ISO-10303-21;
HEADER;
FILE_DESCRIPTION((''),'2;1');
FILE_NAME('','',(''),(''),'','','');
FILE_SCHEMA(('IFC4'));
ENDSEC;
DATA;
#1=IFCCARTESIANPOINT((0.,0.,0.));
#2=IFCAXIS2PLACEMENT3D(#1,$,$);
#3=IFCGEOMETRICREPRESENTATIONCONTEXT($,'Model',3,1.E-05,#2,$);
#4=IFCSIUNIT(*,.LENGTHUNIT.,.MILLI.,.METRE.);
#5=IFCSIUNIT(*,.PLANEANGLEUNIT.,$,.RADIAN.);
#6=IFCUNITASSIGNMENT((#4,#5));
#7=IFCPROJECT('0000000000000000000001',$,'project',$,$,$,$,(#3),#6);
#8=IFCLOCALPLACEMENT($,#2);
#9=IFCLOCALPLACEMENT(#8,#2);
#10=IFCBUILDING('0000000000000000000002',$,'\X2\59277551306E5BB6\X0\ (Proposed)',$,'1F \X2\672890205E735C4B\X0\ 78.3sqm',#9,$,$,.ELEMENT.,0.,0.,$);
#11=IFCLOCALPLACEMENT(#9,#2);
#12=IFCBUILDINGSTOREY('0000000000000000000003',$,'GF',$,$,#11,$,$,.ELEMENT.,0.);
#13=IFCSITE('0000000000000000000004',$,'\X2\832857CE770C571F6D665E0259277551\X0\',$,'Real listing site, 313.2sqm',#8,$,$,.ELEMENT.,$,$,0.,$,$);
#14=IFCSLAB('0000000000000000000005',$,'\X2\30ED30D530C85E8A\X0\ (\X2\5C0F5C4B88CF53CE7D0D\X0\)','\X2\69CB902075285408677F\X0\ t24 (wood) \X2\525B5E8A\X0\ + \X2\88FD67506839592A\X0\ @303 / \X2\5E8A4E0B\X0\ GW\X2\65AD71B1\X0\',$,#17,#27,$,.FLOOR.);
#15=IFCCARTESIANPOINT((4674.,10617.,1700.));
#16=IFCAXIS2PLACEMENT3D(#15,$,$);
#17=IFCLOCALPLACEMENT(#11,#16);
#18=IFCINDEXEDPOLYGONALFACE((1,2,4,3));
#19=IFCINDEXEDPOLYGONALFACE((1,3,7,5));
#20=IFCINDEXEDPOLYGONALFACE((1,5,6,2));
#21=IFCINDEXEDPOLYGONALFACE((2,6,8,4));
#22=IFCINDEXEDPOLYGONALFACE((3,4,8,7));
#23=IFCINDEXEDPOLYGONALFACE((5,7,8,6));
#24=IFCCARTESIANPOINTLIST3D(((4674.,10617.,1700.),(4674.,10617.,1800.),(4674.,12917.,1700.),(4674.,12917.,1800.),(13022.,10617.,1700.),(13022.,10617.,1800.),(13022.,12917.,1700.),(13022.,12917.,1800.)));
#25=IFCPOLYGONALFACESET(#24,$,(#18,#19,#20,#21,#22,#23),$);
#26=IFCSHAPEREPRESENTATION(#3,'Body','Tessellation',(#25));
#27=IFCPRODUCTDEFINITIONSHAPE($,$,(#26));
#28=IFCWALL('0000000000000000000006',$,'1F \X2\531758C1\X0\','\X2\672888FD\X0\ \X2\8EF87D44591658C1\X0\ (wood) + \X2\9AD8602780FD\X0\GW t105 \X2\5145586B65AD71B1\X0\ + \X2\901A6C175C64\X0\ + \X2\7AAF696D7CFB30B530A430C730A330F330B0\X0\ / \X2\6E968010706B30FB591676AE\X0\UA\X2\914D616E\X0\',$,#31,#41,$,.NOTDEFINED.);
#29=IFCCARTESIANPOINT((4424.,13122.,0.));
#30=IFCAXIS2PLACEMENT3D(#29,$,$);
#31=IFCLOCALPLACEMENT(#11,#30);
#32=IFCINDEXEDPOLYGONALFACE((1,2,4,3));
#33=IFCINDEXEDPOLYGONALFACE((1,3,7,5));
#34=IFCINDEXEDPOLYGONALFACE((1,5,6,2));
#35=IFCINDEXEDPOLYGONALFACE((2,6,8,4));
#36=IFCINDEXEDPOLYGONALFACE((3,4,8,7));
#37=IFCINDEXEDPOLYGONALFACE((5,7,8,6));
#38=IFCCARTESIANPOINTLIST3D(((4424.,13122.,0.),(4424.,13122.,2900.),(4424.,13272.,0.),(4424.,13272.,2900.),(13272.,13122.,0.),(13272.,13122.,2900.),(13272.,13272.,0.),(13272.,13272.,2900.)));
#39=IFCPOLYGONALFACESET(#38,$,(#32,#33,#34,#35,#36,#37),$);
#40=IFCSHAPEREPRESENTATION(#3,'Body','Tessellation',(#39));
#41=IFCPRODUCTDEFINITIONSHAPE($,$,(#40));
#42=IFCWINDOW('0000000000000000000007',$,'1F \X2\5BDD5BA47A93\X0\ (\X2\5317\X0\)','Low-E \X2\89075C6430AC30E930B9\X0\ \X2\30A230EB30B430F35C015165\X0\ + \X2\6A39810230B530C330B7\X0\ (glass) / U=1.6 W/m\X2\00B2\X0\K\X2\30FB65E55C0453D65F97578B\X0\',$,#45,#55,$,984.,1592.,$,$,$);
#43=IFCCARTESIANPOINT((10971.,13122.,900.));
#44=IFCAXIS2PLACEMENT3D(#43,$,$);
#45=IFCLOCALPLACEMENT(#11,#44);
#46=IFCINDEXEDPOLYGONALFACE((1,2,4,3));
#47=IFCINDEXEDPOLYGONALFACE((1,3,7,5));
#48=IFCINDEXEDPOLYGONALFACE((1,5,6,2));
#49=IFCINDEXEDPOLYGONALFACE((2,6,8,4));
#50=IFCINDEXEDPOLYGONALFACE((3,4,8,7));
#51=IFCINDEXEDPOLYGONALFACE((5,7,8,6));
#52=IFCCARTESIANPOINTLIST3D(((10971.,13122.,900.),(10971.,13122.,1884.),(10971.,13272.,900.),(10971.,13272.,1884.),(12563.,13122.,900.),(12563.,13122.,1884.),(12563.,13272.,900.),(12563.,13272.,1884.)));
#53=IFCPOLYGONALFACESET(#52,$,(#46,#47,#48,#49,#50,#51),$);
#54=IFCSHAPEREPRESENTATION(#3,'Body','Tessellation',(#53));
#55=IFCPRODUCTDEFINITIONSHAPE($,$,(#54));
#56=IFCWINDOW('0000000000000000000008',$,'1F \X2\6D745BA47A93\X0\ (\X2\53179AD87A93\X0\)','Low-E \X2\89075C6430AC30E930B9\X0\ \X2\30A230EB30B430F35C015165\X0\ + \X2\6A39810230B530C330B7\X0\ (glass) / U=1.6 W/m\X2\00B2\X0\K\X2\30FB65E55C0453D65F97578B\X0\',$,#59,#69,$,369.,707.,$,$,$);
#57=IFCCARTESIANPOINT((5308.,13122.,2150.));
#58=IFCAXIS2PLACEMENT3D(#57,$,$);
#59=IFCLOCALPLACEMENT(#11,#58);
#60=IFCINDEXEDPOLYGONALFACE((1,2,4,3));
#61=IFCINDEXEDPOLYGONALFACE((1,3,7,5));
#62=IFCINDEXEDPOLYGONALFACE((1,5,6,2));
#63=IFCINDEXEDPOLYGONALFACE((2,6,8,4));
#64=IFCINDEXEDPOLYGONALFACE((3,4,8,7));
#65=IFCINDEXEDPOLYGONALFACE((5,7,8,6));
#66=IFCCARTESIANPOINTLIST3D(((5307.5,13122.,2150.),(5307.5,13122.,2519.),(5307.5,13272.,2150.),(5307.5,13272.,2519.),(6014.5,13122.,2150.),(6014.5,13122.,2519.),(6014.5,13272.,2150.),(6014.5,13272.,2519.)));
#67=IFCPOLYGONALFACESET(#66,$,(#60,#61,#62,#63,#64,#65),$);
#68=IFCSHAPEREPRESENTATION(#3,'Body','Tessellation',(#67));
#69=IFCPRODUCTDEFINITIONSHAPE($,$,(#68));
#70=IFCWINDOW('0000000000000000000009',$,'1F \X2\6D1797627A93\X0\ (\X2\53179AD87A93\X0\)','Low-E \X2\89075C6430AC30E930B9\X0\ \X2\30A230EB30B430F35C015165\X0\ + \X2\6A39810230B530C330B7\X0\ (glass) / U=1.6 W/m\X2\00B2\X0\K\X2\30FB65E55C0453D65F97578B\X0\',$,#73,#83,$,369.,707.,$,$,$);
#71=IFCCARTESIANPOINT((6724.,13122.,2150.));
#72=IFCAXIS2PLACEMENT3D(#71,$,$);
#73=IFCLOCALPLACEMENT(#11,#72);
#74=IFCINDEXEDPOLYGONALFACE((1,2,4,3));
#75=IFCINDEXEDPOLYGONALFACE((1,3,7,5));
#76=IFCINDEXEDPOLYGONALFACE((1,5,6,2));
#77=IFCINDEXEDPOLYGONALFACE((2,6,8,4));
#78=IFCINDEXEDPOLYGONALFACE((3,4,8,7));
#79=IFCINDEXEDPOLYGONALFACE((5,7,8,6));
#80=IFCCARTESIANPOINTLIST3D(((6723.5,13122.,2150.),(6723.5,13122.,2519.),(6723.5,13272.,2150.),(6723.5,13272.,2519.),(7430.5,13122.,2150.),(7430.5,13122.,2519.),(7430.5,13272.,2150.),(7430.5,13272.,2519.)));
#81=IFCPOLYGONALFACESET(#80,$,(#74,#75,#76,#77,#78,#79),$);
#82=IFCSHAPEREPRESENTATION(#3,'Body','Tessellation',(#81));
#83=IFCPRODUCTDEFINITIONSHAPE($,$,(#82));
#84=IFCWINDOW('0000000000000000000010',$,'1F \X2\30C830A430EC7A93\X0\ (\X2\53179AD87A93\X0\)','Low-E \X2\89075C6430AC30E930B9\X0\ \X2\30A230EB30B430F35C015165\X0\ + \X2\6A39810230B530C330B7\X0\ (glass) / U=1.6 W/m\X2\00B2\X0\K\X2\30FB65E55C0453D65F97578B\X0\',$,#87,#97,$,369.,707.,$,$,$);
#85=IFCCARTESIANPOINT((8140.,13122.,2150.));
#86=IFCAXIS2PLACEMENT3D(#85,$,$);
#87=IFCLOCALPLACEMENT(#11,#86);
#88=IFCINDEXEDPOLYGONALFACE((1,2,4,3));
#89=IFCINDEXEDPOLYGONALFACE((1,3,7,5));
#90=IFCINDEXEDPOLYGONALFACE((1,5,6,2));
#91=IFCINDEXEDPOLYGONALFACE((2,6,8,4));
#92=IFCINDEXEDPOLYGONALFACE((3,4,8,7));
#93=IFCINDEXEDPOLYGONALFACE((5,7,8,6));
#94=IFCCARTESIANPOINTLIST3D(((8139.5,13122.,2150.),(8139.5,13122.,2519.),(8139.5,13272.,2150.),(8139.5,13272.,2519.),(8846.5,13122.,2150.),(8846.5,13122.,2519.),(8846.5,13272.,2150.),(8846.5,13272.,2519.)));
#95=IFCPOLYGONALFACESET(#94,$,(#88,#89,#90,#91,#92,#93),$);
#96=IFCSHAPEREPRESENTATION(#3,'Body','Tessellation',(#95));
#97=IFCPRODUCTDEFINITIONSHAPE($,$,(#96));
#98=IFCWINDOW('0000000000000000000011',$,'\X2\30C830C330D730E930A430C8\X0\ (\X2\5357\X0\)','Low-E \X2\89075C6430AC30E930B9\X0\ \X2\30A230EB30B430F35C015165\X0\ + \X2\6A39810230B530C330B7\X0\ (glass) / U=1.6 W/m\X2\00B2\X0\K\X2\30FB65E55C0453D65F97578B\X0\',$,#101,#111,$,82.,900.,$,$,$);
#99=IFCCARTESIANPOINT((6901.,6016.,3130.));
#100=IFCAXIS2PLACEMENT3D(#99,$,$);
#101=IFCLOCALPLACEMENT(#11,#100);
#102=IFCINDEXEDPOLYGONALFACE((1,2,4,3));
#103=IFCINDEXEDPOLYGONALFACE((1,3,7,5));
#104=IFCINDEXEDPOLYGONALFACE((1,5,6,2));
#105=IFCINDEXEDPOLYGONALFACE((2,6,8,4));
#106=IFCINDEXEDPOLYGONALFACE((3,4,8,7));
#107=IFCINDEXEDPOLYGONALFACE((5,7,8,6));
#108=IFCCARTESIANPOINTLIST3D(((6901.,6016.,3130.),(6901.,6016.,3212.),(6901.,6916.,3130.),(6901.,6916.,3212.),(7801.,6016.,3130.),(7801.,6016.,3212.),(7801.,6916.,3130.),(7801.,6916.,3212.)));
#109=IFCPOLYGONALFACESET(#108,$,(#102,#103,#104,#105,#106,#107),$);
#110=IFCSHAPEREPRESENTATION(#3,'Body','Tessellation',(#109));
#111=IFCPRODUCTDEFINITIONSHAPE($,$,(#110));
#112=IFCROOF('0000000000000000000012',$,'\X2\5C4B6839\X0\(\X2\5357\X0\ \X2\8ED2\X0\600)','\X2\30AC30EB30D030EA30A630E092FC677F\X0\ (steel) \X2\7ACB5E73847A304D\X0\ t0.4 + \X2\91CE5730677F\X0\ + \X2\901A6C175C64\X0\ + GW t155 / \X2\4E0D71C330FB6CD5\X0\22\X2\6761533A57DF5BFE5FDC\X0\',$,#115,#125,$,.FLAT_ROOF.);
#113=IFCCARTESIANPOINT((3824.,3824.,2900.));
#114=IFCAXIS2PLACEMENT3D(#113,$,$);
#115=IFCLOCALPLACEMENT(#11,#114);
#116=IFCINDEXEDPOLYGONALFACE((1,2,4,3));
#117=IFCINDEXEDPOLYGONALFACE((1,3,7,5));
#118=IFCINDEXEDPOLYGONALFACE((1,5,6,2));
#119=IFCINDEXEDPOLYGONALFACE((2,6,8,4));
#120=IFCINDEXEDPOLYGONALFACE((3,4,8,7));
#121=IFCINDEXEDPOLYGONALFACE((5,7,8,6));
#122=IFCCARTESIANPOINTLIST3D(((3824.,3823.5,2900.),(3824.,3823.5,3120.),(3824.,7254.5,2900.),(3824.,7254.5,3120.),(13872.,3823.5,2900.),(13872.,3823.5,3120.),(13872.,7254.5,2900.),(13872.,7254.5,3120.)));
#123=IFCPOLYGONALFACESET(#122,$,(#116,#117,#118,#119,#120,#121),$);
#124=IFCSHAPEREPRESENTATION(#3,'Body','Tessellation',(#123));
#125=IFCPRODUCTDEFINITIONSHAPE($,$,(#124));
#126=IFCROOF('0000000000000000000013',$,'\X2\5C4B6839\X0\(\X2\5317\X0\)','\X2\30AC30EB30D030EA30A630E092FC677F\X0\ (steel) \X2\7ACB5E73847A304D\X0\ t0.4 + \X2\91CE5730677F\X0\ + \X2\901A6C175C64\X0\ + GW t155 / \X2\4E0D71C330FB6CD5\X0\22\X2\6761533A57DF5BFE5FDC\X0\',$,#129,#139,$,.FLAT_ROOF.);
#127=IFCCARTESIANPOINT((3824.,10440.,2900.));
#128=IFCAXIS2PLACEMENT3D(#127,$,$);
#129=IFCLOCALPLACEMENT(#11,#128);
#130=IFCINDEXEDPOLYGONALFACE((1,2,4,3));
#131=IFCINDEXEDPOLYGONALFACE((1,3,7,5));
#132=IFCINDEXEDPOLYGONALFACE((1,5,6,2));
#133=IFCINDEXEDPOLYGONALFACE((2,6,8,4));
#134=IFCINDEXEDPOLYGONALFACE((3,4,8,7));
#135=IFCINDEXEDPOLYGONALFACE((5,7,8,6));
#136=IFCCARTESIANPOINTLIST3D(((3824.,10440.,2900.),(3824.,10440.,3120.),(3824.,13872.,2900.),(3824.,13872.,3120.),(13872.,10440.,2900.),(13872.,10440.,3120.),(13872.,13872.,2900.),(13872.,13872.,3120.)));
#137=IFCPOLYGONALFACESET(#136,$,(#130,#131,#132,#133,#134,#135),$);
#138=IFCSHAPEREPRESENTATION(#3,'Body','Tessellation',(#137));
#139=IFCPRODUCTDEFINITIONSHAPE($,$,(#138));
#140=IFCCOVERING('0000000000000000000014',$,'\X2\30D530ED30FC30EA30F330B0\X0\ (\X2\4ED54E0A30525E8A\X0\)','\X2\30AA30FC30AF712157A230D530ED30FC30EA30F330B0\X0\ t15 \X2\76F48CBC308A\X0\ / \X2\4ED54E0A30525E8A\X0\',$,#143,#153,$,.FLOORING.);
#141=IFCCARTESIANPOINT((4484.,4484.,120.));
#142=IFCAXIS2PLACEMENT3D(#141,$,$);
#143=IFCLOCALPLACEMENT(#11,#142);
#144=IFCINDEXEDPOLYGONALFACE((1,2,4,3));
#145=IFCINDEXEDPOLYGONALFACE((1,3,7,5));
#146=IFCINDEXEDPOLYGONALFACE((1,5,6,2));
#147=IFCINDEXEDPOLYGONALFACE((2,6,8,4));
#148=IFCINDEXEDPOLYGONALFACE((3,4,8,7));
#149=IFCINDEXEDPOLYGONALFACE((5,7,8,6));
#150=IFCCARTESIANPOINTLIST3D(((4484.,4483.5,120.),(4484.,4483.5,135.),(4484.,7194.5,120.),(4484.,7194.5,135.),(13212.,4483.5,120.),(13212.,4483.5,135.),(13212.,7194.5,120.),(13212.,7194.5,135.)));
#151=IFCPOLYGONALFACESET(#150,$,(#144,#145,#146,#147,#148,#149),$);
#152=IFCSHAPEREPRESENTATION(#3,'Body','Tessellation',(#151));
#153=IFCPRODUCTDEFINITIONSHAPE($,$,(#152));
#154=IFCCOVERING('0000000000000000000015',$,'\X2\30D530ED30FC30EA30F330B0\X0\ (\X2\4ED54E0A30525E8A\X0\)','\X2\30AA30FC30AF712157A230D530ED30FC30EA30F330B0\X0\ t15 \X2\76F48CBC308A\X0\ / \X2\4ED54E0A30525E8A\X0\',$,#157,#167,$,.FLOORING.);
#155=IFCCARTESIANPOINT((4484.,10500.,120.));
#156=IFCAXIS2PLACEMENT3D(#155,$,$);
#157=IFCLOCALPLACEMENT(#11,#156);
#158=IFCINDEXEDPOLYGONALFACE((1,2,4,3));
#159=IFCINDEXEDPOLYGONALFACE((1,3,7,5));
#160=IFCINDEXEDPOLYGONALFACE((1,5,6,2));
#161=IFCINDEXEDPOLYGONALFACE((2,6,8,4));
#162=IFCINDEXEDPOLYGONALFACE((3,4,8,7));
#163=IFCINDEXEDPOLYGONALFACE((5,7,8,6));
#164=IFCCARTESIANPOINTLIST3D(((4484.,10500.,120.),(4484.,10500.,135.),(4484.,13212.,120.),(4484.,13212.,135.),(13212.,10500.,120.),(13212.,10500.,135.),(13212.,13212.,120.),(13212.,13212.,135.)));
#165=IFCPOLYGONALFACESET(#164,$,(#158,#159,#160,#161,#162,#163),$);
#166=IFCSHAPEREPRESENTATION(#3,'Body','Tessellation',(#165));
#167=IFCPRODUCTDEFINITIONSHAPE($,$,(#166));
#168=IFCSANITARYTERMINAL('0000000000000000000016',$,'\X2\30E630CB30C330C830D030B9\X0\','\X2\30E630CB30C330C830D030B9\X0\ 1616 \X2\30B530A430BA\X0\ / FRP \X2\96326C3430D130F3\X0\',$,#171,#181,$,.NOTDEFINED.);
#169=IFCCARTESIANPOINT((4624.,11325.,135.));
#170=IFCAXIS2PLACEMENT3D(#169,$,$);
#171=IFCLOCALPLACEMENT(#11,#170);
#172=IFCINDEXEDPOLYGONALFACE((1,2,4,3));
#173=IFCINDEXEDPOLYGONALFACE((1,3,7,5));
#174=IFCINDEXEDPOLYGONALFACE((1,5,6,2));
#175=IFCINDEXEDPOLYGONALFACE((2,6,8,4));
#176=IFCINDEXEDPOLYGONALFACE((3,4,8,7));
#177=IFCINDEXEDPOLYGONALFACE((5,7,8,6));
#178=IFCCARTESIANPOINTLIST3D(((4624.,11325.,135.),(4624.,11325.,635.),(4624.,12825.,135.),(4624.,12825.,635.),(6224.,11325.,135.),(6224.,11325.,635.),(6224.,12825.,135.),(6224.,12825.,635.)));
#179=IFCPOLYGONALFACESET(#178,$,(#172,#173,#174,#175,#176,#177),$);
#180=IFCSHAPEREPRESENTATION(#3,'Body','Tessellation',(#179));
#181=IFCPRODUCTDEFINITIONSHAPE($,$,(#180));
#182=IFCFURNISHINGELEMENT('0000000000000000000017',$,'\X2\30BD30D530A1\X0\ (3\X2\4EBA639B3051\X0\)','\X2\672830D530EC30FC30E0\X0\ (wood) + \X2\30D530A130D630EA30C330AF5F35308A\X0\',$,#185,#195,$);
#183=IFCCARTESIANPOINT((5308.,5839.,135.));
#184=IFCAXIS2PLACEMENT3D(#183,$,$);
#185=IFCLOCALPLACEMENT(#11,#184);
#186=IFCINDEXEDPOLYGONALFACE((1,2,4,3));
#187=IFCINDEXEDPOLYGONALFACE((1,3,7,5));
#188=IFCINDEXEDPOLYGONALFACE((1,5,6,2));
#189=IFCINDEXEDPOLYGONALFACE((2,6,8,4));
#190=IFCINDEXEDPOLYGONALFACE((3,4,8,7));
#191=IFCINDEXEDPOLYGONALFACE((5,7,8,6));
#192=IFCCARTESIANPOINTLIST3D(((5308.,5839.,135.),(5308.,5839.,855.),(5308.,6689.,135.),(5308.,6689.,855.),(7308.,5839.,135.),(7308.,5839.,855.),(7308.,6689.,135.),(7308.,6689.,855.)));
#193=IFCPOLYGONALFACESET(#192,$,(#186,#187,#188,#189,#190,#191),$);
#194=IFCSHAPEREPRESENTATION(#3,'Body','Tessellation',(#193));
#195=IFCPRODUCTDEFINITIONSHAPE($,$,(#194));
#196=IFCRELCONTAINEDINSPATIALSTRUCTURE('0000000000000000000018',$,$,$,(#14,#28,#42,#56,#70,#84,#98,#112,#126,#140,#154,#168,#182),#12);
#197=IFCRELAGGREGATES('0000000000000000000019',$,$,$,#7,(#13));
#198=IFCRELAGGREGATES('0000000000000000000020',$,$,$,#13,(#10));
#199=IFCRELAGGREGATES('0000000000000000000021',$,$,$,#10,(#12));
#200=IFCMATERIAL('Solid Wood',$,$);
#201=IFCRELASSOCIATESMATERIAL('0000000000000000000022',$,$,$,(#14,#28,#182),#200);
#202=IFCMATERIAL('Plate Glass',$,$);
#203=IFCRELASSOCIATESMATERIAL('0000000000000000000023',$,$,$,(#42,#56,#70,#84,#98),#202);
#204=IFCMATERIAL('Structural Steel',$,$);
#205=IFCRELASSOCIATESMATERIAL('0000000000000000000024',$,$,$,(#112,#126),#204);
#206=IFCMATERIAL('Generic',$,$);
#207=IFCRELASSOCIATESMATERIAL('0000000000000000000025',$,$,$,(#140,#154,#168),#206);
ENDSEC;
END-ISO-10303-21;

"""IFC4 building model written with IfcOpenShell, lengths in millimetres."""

from ifc_helpers import new_model, si_unit, frame, frame_2d, origin, place, context, project, spatial, rectangle, extrude, material, element, fill, save


model = new_model("IFC4")

# Units and contexts
model_context = context("Model", 3, precision=1e-05, world=origin())
ifc_project = project(units=[si_unit("LENGTHUNIT", "METRE", prefix="MILLI"), si_unit("PLANEANGLEUNIT", "RADIAN")], contexts=[model_context])

# Site, building, storey
site_placement = place(None, origin())
site = spatial("IfcSite", under=ifc_project, at=site_placement, Name="茨城県土浦市大畑", ObjectType="Real listing site, 313.2sqm", CompositionType="ELEMENT", RefElevation=0.0)
building_placement = place(site_placement, origin())
building = spatial("IfcBuilding", under=site, at=building_placement, Name="大畑の家 (Proposed)", ObjectType="1F 木造平屋 78.3sqm", CompositionType="ELEMENT", ElevationOfRefHeight=0.0, ElevationOfTerrain=0.0)
storey_placement = place(building_placement, origin())
storey = spatial("IfcBuildingStorey", under=building, at=storey_placement, Name="GF", CompositionType="ELEMENT", Elevation=0.0)

# Slab
ifc_material_1 = material(Name="Solid Wood")
slab_1_placement = place(storey_placement, frame((4674.0, 10617.0, 1700.0)))
element("IfcSlab", 1, at=slab_1_placement, inside=storey, material=ifc_material_1, Name="ロフト床 (小屋裏収納)", Description="構造用合板 t24 (wood) 剛床 + 製材根太 @303 / 床下 GW断熱", PredefinedType="FLOOR", context=model_context, shape_type="SweptSolid", body=[
    extrude(rectangle(XDim=8348.0, YDim=2300.0, at=frame_2d((4174.0, 1150.0))), frame((4674.0, 10617.0, 1700.0)), (0.0, 0.0, 1.0), 100.0),
])

# Shared definitions
ifc_material_2 = material(Name="Plate Glass")

# Wall, openings, windows
wall_1_placement = place(storey_placement, frame((4424.0, 13122.0, 0.0)))
wall_1 = element("IfcWall", 2, at=wall_1_placement, inside=storey, material=ifc_material_1, Name="1F 北壁", Description="木製 軸組外壁 (wood) + 高性能GW t105 充填断熱 + 通気層 + 窯業系サイディング / 準耐火・外皮UA配慮", PredefinedType="NOTDEFINED", context=model_context, shape_type="SweptSolid", body=[
    extrude(rectangle(XDim=8848.0, YDim=150.0, at=frame_2d((4424.0, 75.0))), frame((4424.0, 13122.0, 0.0)), (0.0, 0.0, 1.0), 2900.0),
])
opening_1_placement = place(storey_placement, frame((10971.0, 13122.0, 900.0)))
opening_1 = element("IfcOpeningElement", 3, at=opening_1_placement, cuts=wall_1, PredefinedType="NOTDEFINED", context=model_context, shape_type="SweptSolid", body=[
    extrude(rectangle(XDim=1592.0, YDim=150.0, at=frame_2d((796.0, 75.0))), frame((10971.0, 13122.0, 900.0)), (0.0, 0.0, 1.0), 984.0),
])
opening_2_placement = place(storey_placement, frame((5308.0, 13122.0, 2150.0)))
opening_2 = element("IfcOpeningElement", 4, at=opening_2_placement, cuts=wall_1, PredefinedType="NOTDEFINED", context=model_context, shape_type="SweptSolid", body=[
    extrude(rectangle(XDim=707.0, YDim=150.0, at=frame_2d((353.0, 75.0))), frame((5308.0, 13122.0, 2150.0)), (0.0, 0.0, 1.0), 369.0),
])
opening_3_placement = place(storey_placement, frame((6724.0, 13122.0, 2150.0)))
opening_3 = element("IfcOpeningElement", 5, at=opening_3_placement, cuts=wall_1, PredefinedType="NOTDEFINED", context=model_context, shape_type="SweptSolid", body=[
    extrude(rectangle(XDim=707.0, YDim=150.0, at=frame_2d((353.0, 75.0))), frame((6724.0, 13122.0, 2150.0)), (0.0, 0.0, 1.0), 369.0),
])
opening_4_placement = place(storey_placement, frame((8140.0, 13122.0, 2150.0)))
opening_4 = element("IfcOpeningElement", 6, at=opening_4_placement, cuts=wall_1, PredefinedType="NOTDEFINED", context=model_context, shape_type="SweptSolid", body=[
    extrude(rectangle(XDim=707.0, YDim=150.0, at=frame_2d((353.0, 75.0))), frame((8140.0, 13122.0, 2150.0)), (0.0, 0.0, 1.0), 369.0),
])
window_1_placement = place(storey_placement, frame((10971.0, 13122.0, 900.0)))
window_1 = element("IfcWindow", 7, at=window_1_placement, inside=storey, material=ifc_material_2, Name="1F 寝室窓 (北)", Description="Low-E 複層ガラス アルゴン封入 + 樹脂サッシ (glass) / U=1.6 W/m²K・日射取得型", OverallHeight=984.0, OverallWidth=1592.0, context=model_context, shape_type="SweptSolid", body=[
    extrude(rectangle(XDim=1592.0, YDim=150.0, at=frame_2d((796.0, 75.0))), frame((10971.0, 13122.0, 900.0)), (0.0, 0.0, 1.0), 984.0),
])
fill(opening_1, window_1)
window_2_placement = place(storey_placement, frame((5308.0, 13122.0, 2150.0)))
window_2 = element("IfcWindow", 8, at=window_2_placement, inside=storey, material=ifc_material_2, Name="1F 浴室窓 (北高窓)", Description="Low-E 複層ガラス アルゴン封入 + 樹脂サッシ (glass) / U=1.6 W/m²K・日射取得型", OverallHeight=369.0, OverallWidth=707.0, context=model_context, shape_type="SweptSolid", body=[
    extrude(rectangle(XDim=707.0, YDim=150.0, at=frame_2d((353.0, 75.0))), frame((5308.0, 13122.0, 2150.0)), (0.0, 0.0, 1.0), 369.0),
])
fill(opening_2, window_2)
window_3_placement = place(storey_placement, frame((6724.0, 13122.0, 2150.0)))
window_3 = element("IfcWindow", 9, at=window_3_placement, inside=storey, material=ifc_material_2, Name="1F 洗面窓 (北高窓)", Description="Low-E 複層ガラス アルゴン封入 + 樹脂サッシ (glass) / U=1.6 W/m²K・日射取得型", OverallHeight=369.0, OverallWidth=707.0, context=model_context, shape_type="SweptSolid", body=[
    extrude(rectangle(XDim=707.0, YDim=150.0, at=frame_2d((353.0, 75.0))), frame((6724.0, 13122.0, 2150.0)), (0.0, 0.0, 1.0), 369.0),
])
fill(opening_3, window_3)
window_4_placement = place(storey_placement, frame((8140.0, 13122.0, 2150.0)))
window_4 = element("IfcWindow", 10, at=window_4_placement, inside=storey, material=ifc_material_2, Name="1F トイレ窓 (北高窓)", Description="Low-E 複層ガラス アルゴン封入 + 樹脂サッシ (glass) / U=1.6 W/m²K・日射取得型", OverallHeight=369.0, OverallWidth=707.0, context=model_context, shape_type="SweptSolid", body=[
    extrude(rectangle(XDim=707.0, YDim=150.0, at=frame_2d((353.0, 75.0))), frame((8140.0, 13122.0, 2150.0)), (0.0, 0.0, 1.0), 369.0),
])
fill(opening_4, window_4)

# Window
window_5_placement = place(storey_placement, frame((6901.0, 6016.0, 3130.0)))
element("IfcWindow", 11, at=window_5_placement, inside=storey, material=ifc_material_2, Name="トップライト (南)", Description="Low-E 複層ガラス アルゴン封入 + 樹脂サッシ (glass) / U=1.6 W/m²K・日射取得型", OverallHeight=82.0, OverallWidth=900.0, context=model_context, shape_type="SweptSolid", body=[
    extrude(rectangle(XDim=900.0, YDim=900.0, at=frame_2d((450.0, 450.0))), frame((6901.0, 6016.0, 3130.0)), (0.0, 0.0, 1.0), 82.0),
])

# Roofs
ifc_material_3 = material(Name="Structural Steel")
roof_1_placement = place(storey_placement, frame((3824.0, 3824.0, 2900.0)))
element("IfcRoof", 12, at=roof_1_placement, inside=storey, material=ifc_material_3, Name="屋根(南 軒600)", Description="ガルバリウム鋼板 (steel) 立平葺き t0.4 + 野地板 + 通気層 + GW t155 / 不燃・法22条区域対応", PredefinedType="FLAT_ROOF", context=model_context, shape_type="SweptSolid", body=[
    extrude(rectangle(XDim=10048.0, YDim=3431.0, at=frame_2d((5024.0, 1715.0))), frame((3824.0, 3824.0, 2900.0)), (0.0, 0.0, 1.0), 220.0),
])
roof_2_placement = place(storey_placement, frame((3824.0, 10440.0, 2900.0)))
element("IfcRoof", 13, at=roof_2_placement, inside=storey, material=ifc_material_3, Name="屋根(北)", Description="ガルバリウム鋼板 (steel) 立平葺き t0.4 + 野地板 + 通気層 + GW t155 / 不燃・法22条区域対応", PredefinedType="FLAT_ROOF", context=model_context, shape_type="SweptSolid", body=[
    extrude(rectangle(XDim=10048.0, YDim=3432.0, at=frame_2d((5024.0, 1716.0))), frame((3824.0, 10440.0, 2900.0)), (0.0, 0.0, 1.0), 220.0),
])

# Coverings
ifc_material_4 = material(Name="Generic")
covering_1_placement = place(storey_placement, frame((4484.0, 4484.0, 120.0)))
element("IfcCovering", 14, at=covering_1_placement, inside=storey, material=ifc_material_4, Name="フローリング (仕上げ床)", Description="オーク無垢フローリング t15 直貼り / 仕上げ床", PredefinedType="FLOORING", context=model_context, shape_type="SweptSolid", body=[
    extrude(rectangle(XDim=8728.0, YDim=2711.0, at=frame_2d((4364.0, 1355.0))), frame((4484.0, 4484.0, 120.0)), (0.0, 0.0, 1.0), 15.0),
])
covering_2_placement = place(storey_placement, frame((4484.0, 10500.0, 120.0)))
element("IfcCovering", 15, at=covering_2_placement, inside=storey, material=ifc_material_4, Name="フローリング (仕上げ床)", Description="オーク無垢フローリング t15 直貼り / 仕上げ床", PredefinedType="FLOORING", context=model_context, shape_type="SweptSolid", body=[
    extrude(rectangle(XDim=8728.0, YDim=2712.0, at=frame_2d((4364.0, 1356.0))), frame((4484.0, 10500.0, 120.0)), (0.0, 0.0, 1.0), 15.0),
])

# Sanitary terminal
sanitary_terminal_placement = place(storey_placement, frame((4624.0, 11325.0, 135.0)))
element("IfcSanitaryTerminal", 16, at=sanitary_terminal_placement, inside=storey, material=ifc_material_4, Name="ユニットバス", Description="ユニットバス 1616 サイズ / FRP 防水パン", PredefinedType="NOTDEFINED", context=model_context, shape_type="SweptSolid", body=[
    extrude(rectangle(XDim=1600.0, YDim=1500.0, at=frame_2d((800.0, 750.0))), frame((4624.0, 11325.0, 135.0)), (0.0, 0.0, 1.0), 500.0),
])

# Furnishing element
furnishing_1_placement = place(storey_placement, frame((5308.0, 5839.0, 135.0)))
element("IfcFurnishingElement", 17, at=furnishing_1_placement, inside=storey, material=ifc_material_1, Name="ソファ (3人掛け)", Description="木フレーム (wood) + ファブリック張り", context=model_context, shape_type="SweptSolid", body=[
    extrude(rectangle(XDim=2000.0, YDim=850.0, at=frame_2d((1000.0, 425.0))), frame((5308.0, 5839.0, 135.0)), (0.0, 0.0, 1.0), 720.0),
])

save(model, "model.ifc")
